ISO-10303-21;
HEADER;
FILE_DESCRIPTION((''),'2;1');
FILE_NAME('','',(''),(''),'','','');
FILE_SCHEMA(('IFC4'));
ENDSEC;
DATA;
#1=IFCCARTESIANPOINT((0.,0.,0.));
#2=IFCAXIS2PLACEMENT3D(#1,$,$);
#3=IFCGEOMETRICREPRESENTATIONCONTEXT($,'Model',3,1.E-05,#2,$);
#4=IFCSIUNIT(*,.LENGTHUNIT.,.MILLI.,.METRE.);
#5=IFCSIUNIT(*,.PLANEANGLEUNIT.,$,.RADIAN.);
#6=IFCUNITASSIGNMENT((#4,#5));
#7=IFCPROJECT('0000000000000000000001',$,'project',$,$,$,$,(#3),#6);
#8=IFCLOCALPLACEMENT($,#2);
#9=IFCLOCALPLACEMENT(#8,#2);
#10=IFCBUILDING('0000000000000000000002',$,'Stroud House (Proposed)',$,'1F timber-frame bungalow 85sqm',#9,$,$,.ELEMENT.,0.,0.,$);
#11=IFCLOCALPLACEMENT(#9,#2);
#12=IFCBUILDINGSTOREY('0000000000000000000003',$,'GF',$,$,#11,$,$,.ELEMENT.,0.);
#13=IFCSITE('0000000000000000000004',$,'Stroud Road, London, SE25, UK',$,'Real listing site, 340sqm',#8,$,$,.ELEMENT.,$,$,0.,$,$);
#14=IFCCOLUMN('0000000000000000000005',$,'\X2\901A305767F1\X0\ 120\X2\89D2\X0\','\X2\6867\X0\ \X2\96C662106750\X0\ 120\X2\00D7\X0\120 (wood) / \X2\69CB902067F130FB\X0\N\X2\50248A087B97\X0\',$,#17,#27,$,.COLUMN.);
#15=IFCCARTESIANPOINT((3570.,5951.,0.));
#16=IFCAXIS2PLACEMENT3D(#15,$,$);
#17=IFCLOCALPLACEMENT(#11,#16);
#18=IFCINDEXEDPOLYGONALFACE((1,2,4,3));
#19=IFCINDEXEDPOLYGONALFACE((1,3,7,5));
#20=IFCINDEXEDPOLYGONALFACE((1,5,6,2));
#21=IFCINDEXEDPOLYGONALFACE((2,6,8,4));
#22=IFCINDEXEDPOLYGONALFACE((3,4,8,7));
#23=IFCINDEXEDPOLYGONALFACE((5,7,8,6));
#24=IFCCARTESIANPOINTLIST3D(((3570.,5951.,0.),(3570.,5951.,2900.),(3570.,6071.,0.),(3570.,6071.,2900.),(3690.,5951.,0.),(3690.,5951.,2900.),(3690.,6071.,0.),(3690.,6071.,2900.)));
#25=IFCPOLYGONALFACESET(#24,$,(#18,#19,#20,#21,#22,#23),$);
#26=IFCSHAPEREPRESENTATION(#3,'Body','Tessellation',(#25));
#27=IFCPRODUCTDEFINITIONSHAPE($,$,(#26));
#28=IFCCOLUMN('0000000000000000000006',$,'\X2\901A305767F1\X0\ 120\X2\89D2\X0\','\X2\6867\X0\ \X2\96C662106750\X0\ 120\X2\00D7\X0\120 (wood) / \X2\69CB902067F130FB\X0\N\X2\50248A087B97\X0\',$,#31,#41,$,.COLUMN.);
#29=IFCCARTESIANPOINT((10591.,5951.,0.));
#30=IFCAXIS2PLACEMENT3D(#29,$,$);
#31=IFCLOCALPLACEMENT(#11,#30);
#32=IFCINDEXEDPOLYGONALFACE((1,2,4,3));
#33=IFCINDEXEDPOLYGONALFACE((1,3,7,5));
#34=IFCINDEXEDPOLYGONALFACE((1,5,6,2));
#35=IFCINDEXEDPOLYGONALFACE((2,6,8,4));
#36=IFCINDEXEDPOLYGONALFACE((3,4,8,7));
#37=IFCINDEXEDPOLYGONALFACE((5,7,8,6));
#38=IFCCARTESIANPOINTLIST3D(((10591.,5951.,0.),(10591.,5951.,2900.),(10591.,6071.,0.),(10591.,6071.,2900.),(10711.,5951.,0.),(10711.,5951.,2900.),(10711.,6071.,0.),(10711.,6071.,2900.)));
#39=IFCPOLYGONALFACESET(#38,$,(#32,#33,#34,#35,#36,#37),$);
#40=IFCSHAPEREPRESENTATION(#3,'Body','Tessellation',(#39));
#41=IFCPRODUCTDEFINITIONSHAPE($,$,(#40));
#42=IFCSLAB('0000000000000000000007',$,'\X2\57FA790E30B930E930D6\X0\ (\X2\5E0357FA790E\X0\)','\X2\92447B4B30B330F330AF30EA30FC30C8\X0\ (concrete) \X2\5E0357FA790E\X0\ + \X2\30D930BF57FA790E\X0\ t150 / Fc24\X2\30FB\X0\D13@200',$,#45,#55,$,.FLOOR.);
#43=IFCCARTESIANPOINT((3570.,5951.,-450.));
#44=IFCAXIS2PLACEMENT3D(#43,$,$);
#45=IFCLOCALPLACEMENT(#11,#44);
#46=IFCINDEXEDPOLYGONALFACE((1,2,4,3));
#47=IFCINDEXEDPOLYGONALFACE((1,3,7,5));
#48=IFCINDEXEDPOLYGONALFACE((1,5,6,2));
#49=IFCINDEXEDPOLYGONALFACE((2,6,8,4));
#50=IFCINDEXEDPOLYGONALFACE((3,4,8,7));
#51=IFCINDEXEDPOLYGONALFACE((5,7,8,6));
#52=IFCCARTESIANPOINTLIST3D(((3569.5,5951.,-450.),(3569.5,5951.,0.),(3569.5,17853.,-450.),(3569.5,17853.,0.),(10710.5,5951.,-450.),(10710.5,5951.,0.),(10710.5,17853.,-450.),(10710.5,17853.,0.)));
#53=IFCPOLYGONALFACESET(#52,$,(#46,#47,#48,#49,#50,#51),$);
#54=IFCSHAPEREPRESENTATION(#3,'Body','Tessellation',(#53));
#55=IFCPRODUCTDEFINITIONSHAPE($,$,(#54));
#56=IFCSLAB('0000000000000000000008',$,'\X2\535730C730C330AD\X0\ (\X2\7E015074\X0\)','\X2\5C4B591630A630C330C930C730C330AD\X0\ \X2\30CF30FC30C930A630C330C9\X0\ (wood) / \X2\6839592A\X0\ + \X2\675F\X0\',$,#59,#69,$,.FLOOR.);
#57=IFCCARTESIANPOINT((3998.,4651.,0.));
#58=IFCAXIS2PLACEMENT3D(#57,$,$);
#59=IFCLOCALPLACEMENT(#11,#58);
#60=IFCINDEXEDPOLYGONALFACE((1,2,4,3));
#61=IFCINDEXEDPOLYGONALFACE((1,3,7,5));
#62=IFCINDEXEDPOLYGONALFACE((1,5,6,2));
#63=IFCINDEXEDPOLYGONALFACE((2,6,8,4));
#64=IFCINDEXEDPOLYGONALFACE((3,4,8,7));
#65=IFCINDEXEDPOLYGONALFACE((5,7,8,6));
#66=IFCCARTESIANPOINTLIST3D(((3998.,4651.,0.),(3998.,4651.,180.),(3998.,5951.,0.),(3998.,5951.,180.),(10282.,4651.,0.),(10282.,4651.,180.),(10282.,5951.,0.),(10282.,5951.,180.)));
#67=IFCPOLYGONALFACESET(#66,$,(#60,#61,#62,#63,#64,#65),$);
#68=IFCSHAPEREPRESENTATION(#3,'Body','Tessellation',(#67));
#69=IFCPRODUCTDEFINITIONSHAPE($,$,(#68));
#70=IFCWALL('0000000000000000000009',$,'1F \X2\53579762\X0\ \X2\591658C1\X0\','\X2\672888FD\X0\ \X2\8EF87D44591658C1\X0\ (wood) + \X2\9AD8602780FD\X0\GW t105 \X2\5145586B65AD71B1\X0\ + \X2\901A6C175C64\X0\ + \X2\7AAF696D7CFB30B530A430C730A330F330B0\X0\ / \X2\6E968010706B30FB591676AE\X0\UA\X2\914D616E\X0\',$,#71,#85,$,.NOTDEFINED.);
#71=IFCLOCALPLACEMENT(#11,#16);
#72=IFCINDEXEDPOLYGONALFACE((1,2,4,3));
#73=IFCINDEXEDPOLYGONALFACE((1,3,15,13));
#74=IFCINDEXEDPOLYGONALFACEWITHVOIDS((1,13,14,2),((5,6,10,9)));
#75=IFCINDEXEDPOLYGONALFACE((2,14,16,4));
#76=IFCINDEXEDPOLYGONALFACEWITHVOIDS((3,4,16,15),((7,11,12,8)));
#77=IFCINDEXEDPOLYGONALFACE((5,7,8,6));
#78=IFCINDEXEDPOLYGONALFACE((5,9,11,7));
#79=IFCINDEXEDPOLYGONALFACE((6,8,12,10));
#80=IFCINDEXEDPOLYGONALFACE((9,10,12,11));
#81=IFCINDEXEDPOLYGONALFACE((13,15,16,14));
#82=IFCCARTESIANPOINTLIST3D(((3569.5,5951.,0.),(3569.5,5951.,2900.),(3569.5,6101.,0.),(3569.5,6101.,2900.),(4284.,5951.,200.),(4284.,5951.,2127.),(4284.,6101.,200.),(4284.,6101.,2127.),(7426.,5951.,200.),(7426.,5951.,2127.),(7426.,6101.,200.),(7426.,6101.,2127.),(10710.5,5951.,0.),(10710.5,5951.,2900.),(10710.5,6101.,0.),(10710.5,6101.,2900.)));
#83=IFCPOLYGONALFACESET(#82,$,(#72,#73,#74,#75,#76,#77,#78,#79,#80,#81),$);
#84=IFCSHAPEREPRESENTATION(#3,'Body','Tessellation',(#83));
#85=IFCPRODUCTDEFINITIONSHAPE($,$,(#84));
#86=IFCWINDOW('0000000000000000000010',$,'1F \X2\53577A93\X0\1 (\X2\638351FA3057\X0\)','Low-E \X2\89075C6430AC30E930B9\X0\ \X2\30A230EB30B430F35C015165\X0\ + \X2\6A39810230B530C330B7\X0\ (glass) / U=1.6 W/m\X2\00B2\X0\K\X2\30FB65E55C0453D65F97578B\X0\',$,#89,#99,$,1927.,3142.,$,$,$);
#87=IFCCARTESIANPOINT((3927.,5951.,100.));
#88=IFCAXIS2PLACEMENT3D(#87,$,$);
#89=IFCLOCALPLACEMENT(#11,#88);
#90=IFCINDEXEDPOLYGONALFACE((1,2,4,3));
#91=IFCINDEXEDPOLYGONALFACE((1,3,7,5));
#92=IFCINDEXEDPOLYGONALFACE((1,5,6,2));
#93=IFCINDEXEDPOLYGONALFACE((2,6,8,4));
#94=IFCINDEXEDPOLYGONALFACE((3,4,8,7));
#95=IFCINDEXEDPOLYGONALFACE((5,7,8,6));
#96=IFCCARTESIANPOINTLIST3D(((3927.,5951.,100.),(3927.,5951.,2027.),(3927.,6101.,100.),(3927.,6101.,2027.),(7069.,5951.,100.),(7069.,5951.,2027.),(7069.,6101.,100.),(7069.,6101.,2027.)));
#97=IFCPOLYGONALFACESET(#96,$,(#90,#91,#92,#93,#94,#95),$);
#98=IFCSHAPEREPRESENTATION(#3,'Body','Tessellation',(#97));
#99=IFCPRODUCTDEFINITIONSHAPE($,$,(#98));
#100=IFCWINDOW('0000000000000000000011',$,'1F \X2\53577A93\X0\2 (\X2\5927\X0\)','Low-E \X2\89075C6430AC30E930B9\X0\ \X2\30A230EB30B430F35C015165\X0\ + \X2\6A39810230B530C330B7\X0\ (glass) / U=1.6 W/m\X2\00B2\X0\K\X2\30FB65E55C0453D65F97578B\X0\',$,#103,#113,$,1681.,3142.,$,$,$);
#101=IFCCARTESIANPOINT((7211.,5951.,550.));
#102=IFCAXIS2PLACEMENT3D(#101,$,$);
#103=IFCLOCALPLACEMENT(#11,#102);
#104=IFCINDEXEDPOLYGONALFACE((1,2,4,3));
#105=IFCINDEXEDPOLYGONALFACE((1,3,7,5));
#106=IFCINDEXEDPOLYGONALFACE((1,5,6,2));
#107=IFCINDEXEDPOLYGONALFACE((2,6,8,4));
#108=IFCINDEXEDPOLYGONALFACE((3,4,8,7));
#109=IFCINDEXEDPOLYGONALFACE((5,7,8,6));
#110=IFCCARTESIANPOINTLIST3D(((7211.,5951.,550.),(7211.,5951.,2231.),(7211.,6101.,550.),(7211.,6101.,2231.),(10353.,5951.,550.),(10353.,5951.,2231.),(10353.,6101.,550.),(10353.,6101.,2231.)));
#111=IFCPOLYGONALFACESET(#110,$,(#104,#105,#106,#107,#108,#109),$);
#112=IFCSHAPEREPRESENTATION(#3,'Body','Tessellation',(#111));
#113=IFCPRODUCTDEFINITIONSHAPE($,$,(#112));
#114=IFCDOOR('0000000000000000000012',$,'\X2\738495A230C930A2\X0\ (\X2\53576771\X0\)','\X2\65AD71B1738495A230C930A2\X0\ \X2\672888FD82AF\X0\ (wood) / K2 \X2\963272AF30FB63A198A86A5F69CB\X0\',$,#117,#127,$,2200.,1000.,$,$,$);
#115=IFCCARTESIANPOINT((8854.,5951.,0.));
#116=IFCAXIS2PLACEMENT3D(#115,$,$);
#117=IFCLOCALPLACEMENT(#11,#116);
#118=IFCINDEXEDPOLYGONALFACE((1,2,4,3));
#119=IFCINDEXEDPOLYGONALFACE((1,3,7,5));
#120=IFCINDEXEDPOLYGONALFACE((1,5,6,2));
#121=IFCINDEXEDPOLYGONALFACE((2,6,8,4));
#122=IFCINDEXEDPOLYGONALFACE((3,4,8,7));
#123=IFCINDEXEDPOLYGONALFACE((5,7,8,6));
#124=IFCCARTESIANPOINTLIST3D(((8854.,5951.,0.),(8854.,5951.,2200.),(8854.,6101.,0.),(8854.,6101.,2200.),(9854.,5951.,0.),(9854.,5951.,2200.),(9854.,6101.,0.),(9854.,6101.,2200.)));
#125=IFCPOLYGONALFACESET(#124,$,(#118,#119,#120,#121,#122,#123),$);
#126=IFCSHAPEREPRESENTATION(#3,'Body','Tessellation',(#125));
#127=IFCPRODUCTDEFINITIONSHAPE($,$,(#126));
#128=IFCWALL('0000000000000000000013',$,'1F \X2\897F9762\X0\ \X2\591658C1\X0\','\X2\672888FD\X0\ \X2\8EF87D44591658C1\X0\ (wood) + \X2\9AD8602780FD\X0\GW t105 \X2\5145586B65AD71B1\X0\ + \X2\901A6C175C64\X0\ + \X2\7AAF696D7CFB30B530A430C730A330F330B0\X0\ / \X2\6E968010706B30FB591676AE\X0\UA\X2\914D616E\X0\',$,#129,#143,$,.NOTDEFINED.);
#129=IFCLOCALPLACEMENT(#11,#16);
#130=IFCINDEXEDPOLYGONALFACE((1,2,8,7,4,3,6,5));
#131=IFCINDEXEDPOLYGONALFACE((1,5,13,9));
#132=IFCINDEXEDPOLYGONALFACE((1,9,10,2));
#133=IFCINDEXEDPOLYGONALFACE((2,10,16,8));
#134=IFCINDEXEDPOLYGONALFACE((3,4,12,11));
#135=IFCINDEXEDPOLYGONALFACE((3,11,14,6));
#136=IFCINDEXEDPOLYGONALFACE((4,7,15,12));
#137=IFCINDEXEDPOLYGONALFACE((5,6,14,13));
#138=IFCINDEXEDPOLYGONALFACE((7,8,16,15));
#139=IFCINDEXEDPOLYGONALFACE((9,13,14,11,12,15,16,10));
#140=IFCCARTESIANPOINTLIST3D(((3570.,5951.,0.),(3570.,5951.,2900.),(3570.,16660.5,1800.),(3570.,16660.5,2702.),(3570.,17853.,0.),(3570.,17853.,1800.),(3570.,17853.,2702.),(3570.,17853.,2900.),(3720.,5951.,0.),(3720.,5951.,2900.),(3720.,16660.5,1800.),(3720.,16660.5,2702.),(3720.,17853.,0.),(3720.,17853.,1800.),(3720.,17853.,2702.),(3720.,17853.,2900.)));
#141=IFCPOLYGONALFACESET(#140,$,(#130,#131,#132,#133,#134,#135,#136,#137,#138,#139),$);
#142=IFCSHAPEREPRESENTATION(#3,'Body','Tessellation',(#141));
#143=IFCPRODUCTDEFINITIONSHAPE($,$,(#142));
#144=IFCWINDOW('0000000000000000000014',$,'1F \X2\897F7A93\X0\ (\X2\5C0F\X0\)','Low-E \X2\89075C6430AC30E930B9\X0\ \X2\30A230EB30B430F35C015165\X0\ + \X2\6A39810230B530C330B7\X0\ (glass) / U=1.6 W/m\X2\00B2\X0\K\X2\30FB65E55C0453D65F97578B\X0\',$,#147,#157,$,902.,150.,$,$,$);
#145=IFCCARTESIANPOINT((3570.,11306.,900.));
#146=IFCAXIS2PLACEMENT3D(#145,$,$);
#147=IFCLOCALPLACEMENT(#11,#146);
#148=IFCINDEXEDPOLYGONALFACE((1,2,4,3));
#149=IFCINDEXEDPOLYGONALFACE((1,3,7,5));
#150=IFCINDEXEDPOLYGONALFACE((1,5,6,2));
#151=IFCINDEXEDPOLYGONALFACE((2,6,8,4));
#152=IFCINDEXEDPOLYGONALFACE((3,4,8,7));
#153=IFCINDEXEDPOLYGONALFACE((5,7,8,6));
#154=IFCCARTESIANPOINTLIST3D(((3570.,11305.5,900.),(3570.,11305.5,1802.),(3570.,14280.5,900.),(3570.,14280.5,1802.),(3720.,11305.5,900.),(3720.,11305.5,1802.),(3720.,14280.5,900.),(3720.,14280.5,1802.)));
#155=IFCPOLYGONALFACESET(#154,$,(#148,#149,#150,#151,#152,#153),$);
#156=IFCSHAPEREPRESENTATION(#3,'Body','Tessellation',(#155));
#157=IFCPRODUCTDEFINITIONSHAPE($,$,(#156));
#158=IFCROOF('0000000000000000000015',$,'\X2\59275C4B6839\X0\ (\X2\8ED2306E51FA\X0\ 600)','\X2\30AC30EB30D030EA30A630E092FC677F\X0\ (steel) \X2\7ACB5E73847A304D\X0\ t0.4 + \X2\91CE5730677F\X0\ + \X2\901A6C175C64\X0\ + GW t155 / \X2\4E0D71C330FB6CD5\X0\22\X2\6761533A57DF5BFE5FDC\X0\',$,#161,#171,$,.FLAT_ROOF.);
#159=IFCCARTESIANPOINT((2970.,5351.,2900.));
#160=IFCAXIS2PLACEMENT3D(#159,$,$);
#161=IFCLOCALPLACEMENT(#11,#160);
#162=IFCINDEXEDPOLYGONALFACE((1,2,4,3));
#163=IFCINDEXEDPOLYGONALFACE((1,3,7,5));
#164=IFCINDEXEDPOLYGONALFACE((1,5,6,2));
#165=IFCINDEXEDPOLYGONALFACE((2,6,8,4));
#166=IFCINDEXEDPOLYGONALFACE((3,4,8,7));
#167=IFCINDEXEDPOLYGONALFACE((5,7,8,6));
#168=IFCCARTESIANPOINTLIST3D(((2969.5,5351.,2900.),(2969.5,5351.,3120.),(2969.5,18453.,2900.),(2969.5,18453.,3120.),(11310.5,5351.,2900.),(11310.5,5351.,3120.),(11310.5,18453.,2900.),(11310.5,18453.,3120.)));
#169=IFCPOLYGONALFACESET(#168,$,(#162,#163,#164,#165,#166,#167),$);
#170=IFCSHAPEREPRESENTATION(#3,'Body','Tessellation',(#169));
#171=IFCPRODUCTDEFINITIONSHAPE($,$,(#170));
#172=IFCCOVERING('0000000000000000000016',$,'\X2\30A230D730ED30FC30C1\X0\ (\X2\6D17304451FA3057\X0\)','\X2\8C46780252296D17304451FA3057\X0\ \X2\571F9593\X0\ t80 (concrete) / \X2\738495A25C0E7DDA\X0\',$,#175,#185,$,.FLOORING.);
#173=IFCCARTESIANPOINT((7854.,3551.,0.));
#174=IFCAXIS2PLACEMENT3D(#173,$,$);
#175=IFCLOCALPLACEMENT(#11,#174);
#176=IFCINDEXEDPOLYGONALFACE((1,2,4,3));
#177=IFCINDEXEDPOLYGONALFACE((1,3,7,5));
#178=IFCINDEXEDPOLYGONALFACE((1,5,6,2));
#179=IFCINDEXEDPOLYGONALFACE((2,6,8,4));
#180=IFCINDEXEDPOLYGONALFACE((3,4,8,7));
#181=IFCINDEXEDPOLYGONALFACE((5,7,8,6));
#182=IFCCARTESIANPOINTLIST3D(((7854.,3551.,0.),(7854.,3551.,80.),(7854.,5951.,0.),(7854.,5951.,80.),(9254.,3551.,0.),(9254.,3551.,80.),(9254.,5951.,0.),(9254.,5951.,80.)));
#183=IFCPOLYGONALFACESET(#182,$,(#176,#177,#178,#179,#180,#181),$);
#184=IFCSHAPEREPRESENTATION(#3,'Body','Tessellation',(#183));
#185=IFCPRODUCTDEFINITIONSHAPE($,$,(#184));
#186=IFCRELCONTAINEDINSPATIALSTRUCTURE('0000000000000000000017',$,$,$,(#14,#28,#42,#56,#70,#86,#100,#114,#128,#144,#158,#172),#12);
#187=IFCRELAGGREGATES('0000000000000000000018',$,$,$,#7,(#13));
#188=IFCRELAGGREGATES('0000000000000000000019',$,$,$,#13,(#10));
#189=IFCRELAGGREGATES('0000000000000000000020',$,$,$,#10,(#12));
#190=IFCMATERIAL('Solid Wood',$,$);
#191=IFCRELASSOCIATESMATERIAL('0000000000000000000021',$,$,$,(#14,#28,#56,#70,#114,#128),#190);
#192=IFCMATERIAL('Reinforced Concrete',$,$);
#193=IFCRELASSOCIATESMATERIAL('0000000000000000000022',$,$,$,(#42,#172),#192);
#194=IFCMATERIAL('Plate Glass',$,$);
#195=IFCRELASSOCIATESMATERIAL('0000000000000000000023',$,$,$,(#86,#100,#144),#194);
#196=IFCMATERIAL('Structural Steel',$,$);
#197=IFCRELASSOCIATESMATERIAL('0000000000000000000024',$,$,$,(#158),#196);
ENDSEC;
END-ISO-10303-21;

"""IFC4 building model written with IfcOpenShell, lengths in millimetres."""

from ifc_helpers import new_model, si_unit, frame, frame_2d, origin, place, context, project, spatial, rectangle, extrude, material, element, fill, save


model = new_model("IFC4")

# Units and contexts
model_context = context("Model", 3, precision=1e-05, world=origin())
ifc_project = project(units=[si_unit("LENGTHUNIT", "METRE", prefix="MILLI"), si_unit("PLANEANGLEUNIT", "RADIAN")], contexts=[model_context])

# Site, building, storey
site_placement = place(None, origin())
site = spatial("IfcSite", under=ifc_project, at=site_placement, Name="Stroud Road, London, SE25, UK", ObjectType="Real listing site, 340sqm", CompositionType="ELEMENT", RefElevation=0.0)
building_placement = place(site_placement, origin())
building = spatial("IfcBuilding", under=site, at=building_placement, Name="Stroud House (Proposed)", ObjectType="1F timber-frame bungalow 85sqm", CompositionType="ELEMENT", ElevationOfRefHeight=0.0, ElevationOfTerrain=0.0)
storey_placement = place(building_placement, origin())
storey = spatial("IfcBuildingStorey", under=building, at=storey_placement, Name="GF", CompositionType="ELEMENT", Elevation=0.0)

# Columns
ifc_material_1 = material(Name="Solid Wood")
column_1_placement = place(storey_placement, frame((3570.0, 5951.0, 0.0)))
element("IfcColumn", 1, at=column_1_placement, inside=storey, material=ifc_material_1, Name="通し柱 120角", Description="桧 集成材 120×120 (wood) / 構造柱・N値計算", PredefinedType="COLUMN", context=model_context, shape_type="SweptSolid", body=[
    extrude(rectangle(XDim=120.0, YDim=120.0, at=frame_2d((60.0, 60.0))), frame((3570.0, 5951.0, 0.0)), (0.0, 0.0, 1.0), 2900.0),
])
column_2_placement = place(storey_placement, frame((10591.0, 5951.0, 0.0)))
element("IfcColumn", 2, at=column_2_placement, inside=storey, material=ifc_material_1, Name="通し柱 120角", Description="桧 集成材 120×120 (wood) / 構造柱・N値計算", PredefinedType="COLUMN", context=model_context, shape_type="SweptSolid", body=[
    extrude(rectangle(XDim=120.0, YDim=120.0, at=frame_2d((60.0, 60.0))), frame((10591.0, 5951.0, 0.0)), (0.0, 0.0, 1.0), 2900.0),
])

# Slabs
ifc_material_2 = material(Name="Reinforced Concrete")
slab_1_placement = place(storey_placement, frame((3570.0, 5951.0, -450.0)))
element("IfcSlab", 3, at=slab_1_placement, inside=storey, material=ifc_material_2, Name="基礎スラブ (布基礎)", Description="鉄筋コンクリート (concrete) 布基礎 + ベタ基礎 t150 / Fc24・D13@200", PredefinedType="FLOOR", context=model_context, shape_type="SweptSolid", body=[
    extrude(rectangle(XDim=7141.0, YDim=11902.0, at=frame_2d((3570.0, 5951.0))), frame((3570.0, 5951.0, -450.0)), (0.0, 0.0, 1.0), 450.0),
])
slab_2_placement = place(storey_placement, frame((3998.0, 4651.0, 0.0)))
element("IfcSlab", 4, at=slab_2_placement, inside=storey, material=ifc_material_1, Name="南デッキ (縁側)", Description="屋外ウッドデッキ ハードウッド (wood) / 根太 + 束", PredefinedType="FLOOR", context=model_context, shape_type="SweptSolid", body=[
    extrude(rectangle(XDim=6284.0, YDim=1300.0, at=frame_2d((3142.0, 650.0))), frame((3998.0, 4651.0, 0.0)), (0.0, 0.0, 1.0), 180.0),
])

# Wall, openings, windows, door
wall_1_placement = place(storey_placement, frame((3570.0, 5951.0, 0.0)))
wall_1 = element("IfcWall", 5, at=wall_1_placement, inside=storey, material=ifc_material_1, Name="1F 南面 外壁", Description="木製 軸組外壁 (wood) + 高性能GW t105 充填断熱 + 通気層 + 窯業系サイディング / 準耐火・外皮UA配慮", PredefinedType="NOTDEFINED", context=model_context, shape_type="SweptSolid", body=[
    extrude(rectangle(XDim=7141.0, YDim=150.0, at=frame_2d((3570.0, 75.0))), frame((3570.0, 5951.0, 0.0)), (0.0, 0.0, 1.0), 2900.0),
])
opening_1_placement = place(storey_placement, frame((3927.0, 5951.0, 100.0)))
opening_1 = element("IfcOpeningElement", 6, at=opening_1_placement, cuts=wall_1, PredefinedType="NOTDEFINED", context=model_context, shape_type="SweptSolid", body=[
    extrude(rectangle(XDim=3142.0, YDim=150.0, at=frame_2d((1571.0, 75.0))), frame((3927.0, 5951.0, 100.0)), (0.0, 0.0, 1.0), 1927.0),
])
opening_2_placement = place(storey_placement, frame((7211.0, 5951.0, 550.0)))
opening_2 = element("IfcOpeningElement", 7, at=opening_2_placement, cuts=wall_1, PredefinedType="NOTDEFINED", context=model_context, shape_type="SweptSolid", body=[
    extrude(rectangle(XDim=3142.0, YDim=150.0, at=frame_2d((1571.0, 75.0))), frame((7211.0, 5951.0, 550.0)), (0.0, 0.0, 1.0), 1681.0),
])
opening_3_placement = place(storey_placement, frame((8854.0, 5951.0, 0.0)))
opening_3 = element("IfcOpeningElement", 8, at=opening_3_placement, cuts=wall_1, PredefinedType="NOTDEFINED", context=model_context, shape_type="SweptSolid", body=[
    extrude(rectangle(XDim=1000.0, YDim=150.0, at=frame_2d((500.0, 75.0))), frame((8854.0, 5951.0, 0.0)), (0.0, 0.0, 1.0), 2200.0),
])
ifc_material_3 = material(Name="Plate Glass")
window_1_placement = place(storey_placement, frame((3927.0, 5951.0, 100.0)))
window_1 = element("IfcWindow", 9, at=window_1_placement, inside=storey, material=ifc_material_3, Name="1F 南窓1 (掃出し)", Description="Low-E 複層ガラス アルゴン封入 + 樹脂サッシ (glass) / U=1.6 W/m²K・日射取得型", OverallHeight=1927.0, OverallWidth=3142.0, context=model_context, shape_type="SweptSolid", body=[
    extrude(rectangle(XDim=3142.0, YDim=150.0, at=frame_2d((1571.0, 75.0))), frame((3927.0, 5951.0, 100.0)), (0.0, 0.0, 1.0), 1927.0),
])
fill(opening_1, window_1)
window_2_placement = place(storey_placement, frame((7211.0, 5951.0, 550.0)))
window_2 = element("IfcWindow", 10, at=window_2_placement, inside=storey, material=ifc_material_3, Name="1F 南窓2 (大)", Description="Low-E 複層ガラス アルゴン封入 + 樹脂サッシ (glass) / U=1.6 W/m²K・日射取得型", OverallHeight=1681.0, OverallWidth=3142.0, context=model_context, shape_type="SweptSolid", body=[
    extrude(rectangle(XDim=3142.0, YDim=150.0, at=frame_2d((1571.0, 75.0))), frame((7211.0, 5951.0, 550.0)), (0.0, 0.0, 1.0), 1681.0),
])
fill(opening_2, window_2)
door_placement = place(storey_placement, frame((8854.0, 5951.0, 0.0)))
door = element("IfcDoor", 11, at=door_placement, inside=storey, material=ifc_material_1, Name="玄関ドア (南東)", Description="断熱玄関ドア 木製芯 (wood) / K2 防犯・採風機構", OverallHeight=2200.0, OverallWidth=1000.0, context=model_context, shape_type="SweptSolid", body=[
    extrude(rectangle(XDim=1000.0, YDim=150.0, at=frame_2d((500.0, 75.0))), frame((8854.0, 5951.0, 0.0)), (0.0, 0.0, 1.0), 2200.0),
])
fill(opening_3, door)

# Wall, opening, window
wall_2_placement = place(storey_placement, frame((3570.0, 5951.0, 0.0)))
wall_2 = element("IfcWall", 12, at=wall_2_placement, inside=storey, material=ifc_material_1, Name="1F 西面 外壁", Description="木製 軸組外壁 (wood) + 高性能GW t105 充填断熱 + 通気層 + 窯業系サイディング / 準耐火・外皮UA配慮", PredefinedType="NOTDEFINED", context=model_context, shape_type="SweptSolid", body=[
    extrude(rectangle(XDim=150.0, YDim=11902.0, at=frame_2d((75.0, 5951.0))), frame((3570.0, 5951.0, 0.0)), (0.0, 0.0, 1.0), 2900.0),
])
opening_4_placement = place(storey_placement, frame((3570.0, 11306.0, 900.0)))
opening_4 = element("IfcOpeningElement", 13, at=opening_4_placement, cuts=wall_2, PredefinedType="NOTDEFINED", context=model_context, shape_type="SweptSolid", body=[
    extrude(rectangle(XDim=150.0, YDim=2975.0, at=frame_2d((75.0, 1487.0))), frame((3570.0, 11306.0, 900.0)), (0.0, 0.0, 1.0), 902.0),
])
window_3_placement = place(storey_placement, frame((3570.0, 11306.0, 900.0)))
window_3 = element("IfcWindow", 14, at=window_3_placement, inside=storey, material=ifc_material_3, Name="1F 西窓 (小)", Description="Low-E 複層ガラス アルゴン封入 + 樹脂サッシ (glass) / U=1.6 W/m²K・日射取得型", OverallHeight=902.0, OverallWidth=150.0, context=model_context, shape_type="SweptSolid", body=[
    extrude(rectangle(XDim=150.0, YDim=2975.0, at=frame_2d((75.0, 1487.0))), frame((3570.0, 11306.0, 900.0)), (0.0, 0.0, 1.0), 902.0),
])
fill(opening_4, window_3)

# Roof
ifc_material_4 = material(Name="Structural Steel")
roof_placement = place(storey_placement, frame((2970.0, 5351.0, 2900.0)))
element("IfcRoof", 15, at=roof_placement, inside=storey, material=ifc_material_4, Name="大屋根 (軒の出 600)", Description="ガルバリウム鋼板 (steel) 立平葺き t0.4 + 野地板 + 通気層 + GW t155 / 不燃・法22条区域対応", PredefinedType="FLAT_ROOF", context=model_context, shape_type="SweptSolid", body=[
    extrude(rectangle(XDim=8341.0, YDim=13102.0, at=frame_2d((4170.0, 6551.0))), frame((2970.0, 5351.0, 2900.0)), (0.0, 0.0, 1.0), 220.0),
])

# Covering
covering_1_placement = place(storey_placement, frame((7854.0, 3551.0, 0.0)))
element("IfcCovering", 16, at=covering_1_placement, inside=storey, material=ifc_material_2, Name="アプローチ (洗い出し)", Description="豆砂利洗い出し 土間 t80 (concrete) / 玄関導線", PredefinedType="FLOORING", context=model_context, shape_type="SweptSolid", body=[
    extrude(rectangle(XDim=1400.0, YDim=2400.0, at=frame_2d((700.0, 1200.0))), frame((7854.0, 3551.0, 0.0)), (0.0, 0.0, 1.0), 80.0),
])

save(model, "model.ifc")
